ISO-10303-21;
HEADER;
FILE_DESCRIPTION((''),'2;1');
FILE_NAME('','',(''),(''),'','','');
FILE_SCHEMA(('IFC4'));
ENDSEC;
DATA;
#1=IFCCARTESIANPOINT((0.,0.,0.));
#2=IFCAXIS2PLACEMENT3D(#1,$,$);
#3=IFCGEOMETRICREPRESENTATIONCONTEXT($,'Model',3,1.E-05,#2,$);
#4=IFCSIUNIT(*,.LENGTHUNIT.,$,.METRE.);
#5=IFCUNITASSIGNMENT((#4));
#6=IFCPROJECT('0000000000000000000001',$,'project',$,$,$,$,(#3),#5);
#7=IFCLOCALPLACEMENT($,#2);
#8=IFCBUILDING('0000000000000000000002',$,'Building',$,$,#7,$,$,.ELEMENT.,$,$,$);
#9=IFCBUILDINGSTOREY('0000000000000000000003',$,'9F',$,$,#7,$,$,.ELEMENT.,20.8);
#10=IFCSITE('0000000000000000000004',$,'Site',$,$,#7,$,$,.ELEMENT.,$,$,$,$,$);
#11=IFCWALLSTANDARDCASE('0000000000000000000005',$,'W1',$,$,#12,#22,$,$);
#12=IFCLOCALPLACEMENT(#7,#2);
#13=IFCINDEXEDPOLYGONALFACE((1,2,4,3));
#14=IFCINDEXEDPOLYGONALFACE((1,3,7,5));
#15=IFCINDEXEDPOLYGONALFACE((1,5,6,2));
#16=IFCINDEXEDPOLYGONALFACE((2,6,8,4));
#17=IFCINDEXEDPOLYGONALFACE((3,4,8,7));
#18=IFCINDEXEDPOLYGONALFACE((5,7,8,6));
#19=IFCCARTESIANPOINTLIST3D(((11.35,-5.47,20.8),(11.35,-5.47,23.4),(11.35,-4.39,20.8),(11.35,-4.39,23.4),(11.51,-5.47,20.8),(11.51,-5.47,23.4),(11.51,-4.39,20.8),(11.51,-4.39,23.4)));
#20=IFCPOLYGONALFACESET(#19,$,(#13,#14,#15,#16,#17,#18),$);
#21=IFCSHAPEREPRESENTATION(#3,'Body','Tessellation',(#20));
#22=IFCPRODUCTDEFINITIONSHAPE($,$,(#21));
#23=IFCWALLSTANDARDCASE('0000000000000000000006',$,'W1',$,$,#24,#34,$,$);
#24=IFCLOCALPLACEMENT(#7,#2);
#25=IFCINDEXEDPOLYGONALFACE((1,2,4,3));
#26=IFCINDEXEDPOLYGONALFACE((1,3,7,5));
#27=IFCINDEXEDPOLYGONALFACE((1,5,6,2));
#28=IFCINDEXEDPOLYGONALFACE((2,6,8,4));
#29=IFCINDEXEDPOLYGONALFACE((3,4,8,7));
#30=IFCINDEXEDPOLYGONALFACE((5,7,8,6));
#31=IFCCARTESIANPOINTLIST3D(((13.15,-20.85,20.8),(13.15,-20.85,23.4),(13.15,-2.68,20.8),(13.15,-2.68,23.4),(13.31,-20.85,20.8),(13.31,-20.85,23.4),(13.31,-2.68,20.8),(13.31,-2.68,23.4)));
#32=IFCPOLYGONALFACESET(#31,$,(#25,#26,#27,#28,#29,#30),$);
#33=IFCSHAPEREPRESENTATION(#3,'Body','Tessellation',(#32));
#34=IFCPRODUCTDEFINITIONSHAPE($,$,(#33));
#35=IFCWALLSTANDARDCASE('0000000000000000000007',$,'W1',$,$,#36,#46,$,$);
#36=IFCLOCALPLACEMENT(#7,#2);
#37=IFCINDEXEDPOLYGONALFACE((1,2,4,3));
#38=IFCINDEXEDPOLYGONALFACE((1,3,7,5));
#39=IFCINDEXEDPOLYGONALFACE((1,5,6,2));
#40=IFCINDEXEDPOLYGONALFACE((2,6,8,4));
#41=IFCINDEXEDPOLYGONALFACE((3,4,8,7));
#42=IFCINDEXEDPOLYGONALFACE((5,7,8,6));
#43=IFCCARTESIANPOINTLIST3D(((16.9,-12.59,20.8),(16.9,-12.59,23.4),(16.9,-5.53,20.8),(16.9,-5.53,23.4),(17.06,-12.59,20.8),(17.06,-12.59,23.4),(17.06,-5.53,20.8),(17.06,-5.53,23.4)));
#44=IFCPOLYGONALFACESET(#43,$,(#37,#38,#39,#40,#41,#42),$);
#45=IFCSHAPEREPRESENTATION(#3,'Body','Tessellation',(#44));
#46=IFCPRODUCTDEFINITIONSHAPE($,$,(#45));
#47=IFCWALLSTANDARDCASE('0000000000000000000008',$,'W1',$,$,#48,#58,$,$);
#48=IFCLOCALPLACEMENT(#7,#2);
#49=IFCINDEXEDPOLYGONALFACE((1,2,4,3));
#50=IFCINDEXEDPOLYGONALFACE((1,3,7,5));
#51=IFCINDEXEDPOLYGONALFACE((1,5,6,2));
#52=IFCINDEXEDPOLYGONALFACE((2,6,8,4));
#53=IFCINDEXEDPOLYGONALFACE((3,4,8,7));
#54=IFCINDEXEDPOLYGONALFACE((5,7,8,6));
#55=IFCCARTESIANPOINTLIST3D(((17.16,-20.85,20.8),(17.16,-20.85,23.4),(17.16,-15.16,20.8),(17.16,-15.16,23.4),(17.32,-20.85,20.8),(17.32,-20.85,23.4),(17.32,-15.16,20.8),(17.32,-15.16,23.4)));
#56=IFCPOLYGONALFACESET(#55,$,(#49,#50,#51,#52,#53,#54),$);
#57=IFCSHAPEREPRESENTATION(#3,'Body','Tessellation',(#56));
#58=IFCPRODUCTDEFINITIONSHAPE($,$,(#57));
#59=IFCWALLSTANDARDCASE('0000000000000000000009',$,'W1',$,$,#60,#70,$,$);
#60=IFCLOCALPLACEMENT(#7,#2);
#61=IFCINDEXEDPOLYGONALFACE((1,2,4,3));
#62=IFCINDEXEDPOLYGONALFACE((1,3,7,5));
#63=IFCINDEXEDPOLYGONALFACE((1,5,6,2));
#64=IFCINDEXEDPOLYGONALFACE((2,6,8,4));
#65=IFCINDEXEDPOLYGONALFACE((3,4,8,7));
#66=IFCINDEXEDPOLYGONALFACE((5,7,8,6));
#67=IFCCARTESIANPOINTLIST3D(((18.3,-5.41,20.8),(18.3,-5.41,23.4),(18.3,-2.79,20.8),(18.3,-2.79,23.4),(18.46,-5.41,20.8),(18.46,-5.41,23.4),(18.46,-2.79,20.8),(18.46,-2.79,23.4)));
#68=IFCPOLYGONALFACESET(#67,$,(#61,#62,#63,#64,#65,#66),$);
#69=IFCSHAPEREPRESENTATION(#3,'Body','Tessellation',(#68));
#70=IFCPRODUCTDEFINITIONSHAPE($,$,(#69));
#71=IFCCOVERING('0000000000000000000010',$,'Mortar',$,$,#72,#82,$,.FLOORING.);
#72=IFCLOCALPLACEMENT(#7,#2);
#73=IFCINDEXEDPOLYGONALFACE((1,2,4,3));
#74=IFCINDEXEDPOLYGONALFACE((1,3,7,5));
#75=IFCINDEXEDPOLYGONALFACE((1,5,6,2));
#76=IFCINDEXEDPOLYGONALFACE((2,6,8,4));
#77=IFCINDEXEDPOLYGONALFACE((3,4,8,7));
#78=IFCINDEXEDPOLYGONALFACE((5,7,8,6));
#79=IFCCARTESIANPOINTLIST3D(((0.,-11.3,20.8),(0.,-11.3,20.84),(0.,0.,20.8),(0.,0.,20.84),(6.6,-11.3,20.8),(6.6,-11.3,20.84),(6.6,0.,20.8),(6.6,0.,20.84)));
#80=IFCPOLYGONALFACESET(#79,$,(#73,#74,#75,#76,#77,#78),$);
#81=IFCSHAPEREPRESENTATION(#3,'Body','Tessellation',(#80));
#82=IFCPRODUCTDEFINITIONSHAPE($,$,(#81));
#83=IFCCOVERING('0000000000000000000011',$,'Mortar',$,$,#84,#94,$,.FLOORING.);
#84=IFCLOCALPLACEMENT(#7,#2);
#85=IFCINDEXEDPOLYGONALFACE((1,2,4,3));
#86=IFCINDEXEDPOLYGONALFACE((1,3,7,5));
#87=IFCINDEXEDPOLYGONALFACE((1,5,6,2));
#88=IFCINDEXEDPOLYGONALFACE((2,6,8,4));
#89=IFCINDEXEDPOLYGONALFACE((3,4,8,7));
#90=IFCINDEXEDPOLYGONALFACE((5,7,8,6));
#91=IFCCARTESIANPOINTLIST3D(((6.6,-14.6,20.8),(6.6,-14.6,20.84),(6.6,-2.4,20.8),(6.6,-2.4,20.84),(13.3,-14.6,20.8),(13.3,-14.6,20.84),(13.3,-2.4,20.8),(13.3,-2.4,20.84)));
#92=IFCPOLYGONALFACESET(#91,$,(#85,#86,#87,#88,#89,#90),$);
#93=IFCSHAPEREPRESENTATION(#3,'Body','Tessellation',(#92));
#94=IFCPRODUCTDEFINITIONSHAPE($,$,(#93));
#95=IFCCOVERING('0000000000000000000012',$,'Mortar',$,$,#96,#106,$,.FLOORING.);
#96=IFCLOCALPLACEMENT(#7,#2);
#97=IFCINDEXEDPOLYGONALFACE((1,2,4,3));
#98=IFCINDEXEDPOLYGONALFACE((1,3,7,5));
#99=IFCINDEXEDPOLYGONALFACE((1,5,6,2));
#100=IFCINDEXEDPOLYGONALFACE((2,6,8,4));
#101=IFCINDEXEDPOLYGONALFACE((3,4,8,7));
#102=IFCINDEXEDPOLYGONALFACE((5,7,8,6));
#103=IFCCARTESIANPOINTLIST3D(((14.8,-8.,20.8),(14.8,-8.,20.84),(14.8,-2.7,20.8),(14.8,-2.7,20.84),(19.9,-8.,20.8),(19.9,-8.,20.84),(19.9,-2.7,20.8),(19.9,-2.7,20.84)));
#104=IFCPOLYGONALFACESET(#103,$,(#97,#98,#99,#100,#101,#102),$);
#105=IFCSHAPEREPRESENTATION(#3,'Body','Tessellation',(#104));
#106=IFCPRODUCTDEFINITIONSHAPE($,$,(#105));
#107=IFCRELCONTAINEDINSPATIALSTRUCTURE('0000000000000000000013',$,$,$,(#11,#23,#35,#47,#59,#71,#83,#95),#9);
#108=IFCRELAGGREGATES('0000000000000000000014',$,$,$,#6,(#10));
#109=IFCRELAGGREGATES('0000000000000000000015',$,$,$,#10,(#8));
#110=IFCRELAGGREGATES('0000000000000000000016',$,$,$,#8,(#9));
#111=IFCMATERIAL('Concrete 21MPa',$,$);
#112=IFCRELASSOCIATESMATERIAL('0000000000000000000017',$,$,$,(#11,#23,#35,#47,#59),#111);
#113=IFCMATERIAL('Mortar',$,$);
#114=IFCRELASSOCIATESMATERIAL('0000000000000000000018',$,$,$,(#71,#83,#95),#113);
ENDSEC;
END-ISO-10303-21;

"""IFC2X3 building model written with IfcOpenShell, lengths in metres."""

from ifc_helpers import new_model, si_unit, frame, origin, origin_2d, place, context, project, spatial, rectangle, extrude, material, element, save


model = new_model("IFC2X3")

# Units and contexts
model_context = context("Model", 3, precision=1e-05, world=origin())
ifc_project = project(units=[si_unit("LENGTHUNIT", "METRE")], contexts=[model_context])

# Site, building, storey
placement = place(None, origin())
site = spatial("IfcSite", under=ifc_project, at=placement, Name="Site", CompositionType="ELEMENT")
building = spatial("IfcBuilding", under=site, at=placement, Name="Building", CompositionType="ELEMENT")
storey = spatial("IfcBuildingStorey", under=building, at=placement, Name="9F", CompositionType="ELEMENT", Elevation=20.8)

# Shared definitions
ifc_material_1 = material(Name="Concrete 21MPa")

# Walls
wall_1_placement = place(None, frame((11.43, -4.93, 20.8)))
element("IfcWallStandardCase", 1, at=wall_1_placement, inside=storey, material=ifc_material_1, Name="W1", context=model_context, shape_type="SweptSolid", body=[
    extrude(rectangle(XDim=0.16, YDim=1.08, at=origin_2d()), origin(), (0.0, 0.0, 1.0), 2.6),
])
wall_2_placement = place(None, frame((13.23, -11.765, 20.8)))
element("IfcWallStandardCase", 2, at=wall_2_placement, inside=storey, material=ifc_material_1, Name="W1", context=model_context, shape_type="SweptSolid", body=[
    extrude(rectangle(XDim=0.16, YDim=18.17, at=origin_2d()), origin(), (0.0, 0.0, 1.0), 2.6),
])
wall_3_placement = place(None, frame((16.98, -9.06, 20.8)))
element("IfcWallStandardCase", 3, at=wall_3_placement, inside=storey, material=ifc_material_1, Name="W1", context=model_context, shape_type="SweptSolid", body=[
    extrude(rectangle(XDim=0.16, YDim=7.06, at=origin_2d()), origin(), (0.0, 0.0, 1.0), 2.6),
])
wall_4_placement = place(None, frame((17.24, -18.005, 20.8)))
element("IfcWallStandardCase", 4, at=wall_4_placement, inside=storey, material=ifc_material_1, Name="W1", context=model_context, shape_type="SweptSolid", body=[
    extrude(rectangle(XDim=0.16, YDim=5.69, at=origin_2d()), origin(), (0.0, 0.0, 1.0), 2.6),
])
wall_5_placement = place(None, frame((18.38, -4.1, 20.8)))
element("IfcWallStandardCase", 5, at=wall_5_placement, inside=storey, material=ifc_material_1, Name="W1", context=model_context, shape_type="SweptSolid", body=[
    extrude(rectangle(XDim=0.16, YDim=2.62, at=origin_2d()), origin(), (0.0, 0.0, 1.0), 2.6),
])

# Coverings
ifc_material_2 = material(Name="Mortar")
covering_1_placement = place(None, frame((3.3, -5.65, 20.8)))
element("IfcCovering", 6, at=covering_1_placement, inside=storey, material=ifc_material_2, Name="Mortar", PredefinedType="FLOORING", context=model_context, shape_type="SweptSolid", body=[
    extrude(rectangle(XDim=6.6, YDim=11.3, at=origin_2d()), origin(), (0.0, 0.0, 1.0), 0.04),
])
covering_2_placement = place(None, frame((9.95, -8.5, 20.8)))
element("IfcCovering", 7, at=covering_2_placement, inside=storey, material=ifc_material_2, Name="Mortar", PredefinedType="FLOORING", context=model_context, shape_type="SweptSolid", body=[
    extrude(rectangle(XDim=6.7, YDim=12.2, at=origin_2d()), origin(), (0.0, 0.0, 1.0), 0.04),
])
covering_3_placement = place(None, frame((17.35, -5.35, 20.8)))
element("IfcCovering", 8, at=covering_3_placement, inside=storey, material=ifc_material_2, Name="Mortar", PredefinedType="FLOORING", context=model_context, shape_type="SweptSolid", body=[
    extrude(rectangle(XDim=5.1, YDim=5.3, at=origin_2d()), origin(), (0.0, 0.0, 1.0), 0.04),
])

save(model, "model.ifc")
